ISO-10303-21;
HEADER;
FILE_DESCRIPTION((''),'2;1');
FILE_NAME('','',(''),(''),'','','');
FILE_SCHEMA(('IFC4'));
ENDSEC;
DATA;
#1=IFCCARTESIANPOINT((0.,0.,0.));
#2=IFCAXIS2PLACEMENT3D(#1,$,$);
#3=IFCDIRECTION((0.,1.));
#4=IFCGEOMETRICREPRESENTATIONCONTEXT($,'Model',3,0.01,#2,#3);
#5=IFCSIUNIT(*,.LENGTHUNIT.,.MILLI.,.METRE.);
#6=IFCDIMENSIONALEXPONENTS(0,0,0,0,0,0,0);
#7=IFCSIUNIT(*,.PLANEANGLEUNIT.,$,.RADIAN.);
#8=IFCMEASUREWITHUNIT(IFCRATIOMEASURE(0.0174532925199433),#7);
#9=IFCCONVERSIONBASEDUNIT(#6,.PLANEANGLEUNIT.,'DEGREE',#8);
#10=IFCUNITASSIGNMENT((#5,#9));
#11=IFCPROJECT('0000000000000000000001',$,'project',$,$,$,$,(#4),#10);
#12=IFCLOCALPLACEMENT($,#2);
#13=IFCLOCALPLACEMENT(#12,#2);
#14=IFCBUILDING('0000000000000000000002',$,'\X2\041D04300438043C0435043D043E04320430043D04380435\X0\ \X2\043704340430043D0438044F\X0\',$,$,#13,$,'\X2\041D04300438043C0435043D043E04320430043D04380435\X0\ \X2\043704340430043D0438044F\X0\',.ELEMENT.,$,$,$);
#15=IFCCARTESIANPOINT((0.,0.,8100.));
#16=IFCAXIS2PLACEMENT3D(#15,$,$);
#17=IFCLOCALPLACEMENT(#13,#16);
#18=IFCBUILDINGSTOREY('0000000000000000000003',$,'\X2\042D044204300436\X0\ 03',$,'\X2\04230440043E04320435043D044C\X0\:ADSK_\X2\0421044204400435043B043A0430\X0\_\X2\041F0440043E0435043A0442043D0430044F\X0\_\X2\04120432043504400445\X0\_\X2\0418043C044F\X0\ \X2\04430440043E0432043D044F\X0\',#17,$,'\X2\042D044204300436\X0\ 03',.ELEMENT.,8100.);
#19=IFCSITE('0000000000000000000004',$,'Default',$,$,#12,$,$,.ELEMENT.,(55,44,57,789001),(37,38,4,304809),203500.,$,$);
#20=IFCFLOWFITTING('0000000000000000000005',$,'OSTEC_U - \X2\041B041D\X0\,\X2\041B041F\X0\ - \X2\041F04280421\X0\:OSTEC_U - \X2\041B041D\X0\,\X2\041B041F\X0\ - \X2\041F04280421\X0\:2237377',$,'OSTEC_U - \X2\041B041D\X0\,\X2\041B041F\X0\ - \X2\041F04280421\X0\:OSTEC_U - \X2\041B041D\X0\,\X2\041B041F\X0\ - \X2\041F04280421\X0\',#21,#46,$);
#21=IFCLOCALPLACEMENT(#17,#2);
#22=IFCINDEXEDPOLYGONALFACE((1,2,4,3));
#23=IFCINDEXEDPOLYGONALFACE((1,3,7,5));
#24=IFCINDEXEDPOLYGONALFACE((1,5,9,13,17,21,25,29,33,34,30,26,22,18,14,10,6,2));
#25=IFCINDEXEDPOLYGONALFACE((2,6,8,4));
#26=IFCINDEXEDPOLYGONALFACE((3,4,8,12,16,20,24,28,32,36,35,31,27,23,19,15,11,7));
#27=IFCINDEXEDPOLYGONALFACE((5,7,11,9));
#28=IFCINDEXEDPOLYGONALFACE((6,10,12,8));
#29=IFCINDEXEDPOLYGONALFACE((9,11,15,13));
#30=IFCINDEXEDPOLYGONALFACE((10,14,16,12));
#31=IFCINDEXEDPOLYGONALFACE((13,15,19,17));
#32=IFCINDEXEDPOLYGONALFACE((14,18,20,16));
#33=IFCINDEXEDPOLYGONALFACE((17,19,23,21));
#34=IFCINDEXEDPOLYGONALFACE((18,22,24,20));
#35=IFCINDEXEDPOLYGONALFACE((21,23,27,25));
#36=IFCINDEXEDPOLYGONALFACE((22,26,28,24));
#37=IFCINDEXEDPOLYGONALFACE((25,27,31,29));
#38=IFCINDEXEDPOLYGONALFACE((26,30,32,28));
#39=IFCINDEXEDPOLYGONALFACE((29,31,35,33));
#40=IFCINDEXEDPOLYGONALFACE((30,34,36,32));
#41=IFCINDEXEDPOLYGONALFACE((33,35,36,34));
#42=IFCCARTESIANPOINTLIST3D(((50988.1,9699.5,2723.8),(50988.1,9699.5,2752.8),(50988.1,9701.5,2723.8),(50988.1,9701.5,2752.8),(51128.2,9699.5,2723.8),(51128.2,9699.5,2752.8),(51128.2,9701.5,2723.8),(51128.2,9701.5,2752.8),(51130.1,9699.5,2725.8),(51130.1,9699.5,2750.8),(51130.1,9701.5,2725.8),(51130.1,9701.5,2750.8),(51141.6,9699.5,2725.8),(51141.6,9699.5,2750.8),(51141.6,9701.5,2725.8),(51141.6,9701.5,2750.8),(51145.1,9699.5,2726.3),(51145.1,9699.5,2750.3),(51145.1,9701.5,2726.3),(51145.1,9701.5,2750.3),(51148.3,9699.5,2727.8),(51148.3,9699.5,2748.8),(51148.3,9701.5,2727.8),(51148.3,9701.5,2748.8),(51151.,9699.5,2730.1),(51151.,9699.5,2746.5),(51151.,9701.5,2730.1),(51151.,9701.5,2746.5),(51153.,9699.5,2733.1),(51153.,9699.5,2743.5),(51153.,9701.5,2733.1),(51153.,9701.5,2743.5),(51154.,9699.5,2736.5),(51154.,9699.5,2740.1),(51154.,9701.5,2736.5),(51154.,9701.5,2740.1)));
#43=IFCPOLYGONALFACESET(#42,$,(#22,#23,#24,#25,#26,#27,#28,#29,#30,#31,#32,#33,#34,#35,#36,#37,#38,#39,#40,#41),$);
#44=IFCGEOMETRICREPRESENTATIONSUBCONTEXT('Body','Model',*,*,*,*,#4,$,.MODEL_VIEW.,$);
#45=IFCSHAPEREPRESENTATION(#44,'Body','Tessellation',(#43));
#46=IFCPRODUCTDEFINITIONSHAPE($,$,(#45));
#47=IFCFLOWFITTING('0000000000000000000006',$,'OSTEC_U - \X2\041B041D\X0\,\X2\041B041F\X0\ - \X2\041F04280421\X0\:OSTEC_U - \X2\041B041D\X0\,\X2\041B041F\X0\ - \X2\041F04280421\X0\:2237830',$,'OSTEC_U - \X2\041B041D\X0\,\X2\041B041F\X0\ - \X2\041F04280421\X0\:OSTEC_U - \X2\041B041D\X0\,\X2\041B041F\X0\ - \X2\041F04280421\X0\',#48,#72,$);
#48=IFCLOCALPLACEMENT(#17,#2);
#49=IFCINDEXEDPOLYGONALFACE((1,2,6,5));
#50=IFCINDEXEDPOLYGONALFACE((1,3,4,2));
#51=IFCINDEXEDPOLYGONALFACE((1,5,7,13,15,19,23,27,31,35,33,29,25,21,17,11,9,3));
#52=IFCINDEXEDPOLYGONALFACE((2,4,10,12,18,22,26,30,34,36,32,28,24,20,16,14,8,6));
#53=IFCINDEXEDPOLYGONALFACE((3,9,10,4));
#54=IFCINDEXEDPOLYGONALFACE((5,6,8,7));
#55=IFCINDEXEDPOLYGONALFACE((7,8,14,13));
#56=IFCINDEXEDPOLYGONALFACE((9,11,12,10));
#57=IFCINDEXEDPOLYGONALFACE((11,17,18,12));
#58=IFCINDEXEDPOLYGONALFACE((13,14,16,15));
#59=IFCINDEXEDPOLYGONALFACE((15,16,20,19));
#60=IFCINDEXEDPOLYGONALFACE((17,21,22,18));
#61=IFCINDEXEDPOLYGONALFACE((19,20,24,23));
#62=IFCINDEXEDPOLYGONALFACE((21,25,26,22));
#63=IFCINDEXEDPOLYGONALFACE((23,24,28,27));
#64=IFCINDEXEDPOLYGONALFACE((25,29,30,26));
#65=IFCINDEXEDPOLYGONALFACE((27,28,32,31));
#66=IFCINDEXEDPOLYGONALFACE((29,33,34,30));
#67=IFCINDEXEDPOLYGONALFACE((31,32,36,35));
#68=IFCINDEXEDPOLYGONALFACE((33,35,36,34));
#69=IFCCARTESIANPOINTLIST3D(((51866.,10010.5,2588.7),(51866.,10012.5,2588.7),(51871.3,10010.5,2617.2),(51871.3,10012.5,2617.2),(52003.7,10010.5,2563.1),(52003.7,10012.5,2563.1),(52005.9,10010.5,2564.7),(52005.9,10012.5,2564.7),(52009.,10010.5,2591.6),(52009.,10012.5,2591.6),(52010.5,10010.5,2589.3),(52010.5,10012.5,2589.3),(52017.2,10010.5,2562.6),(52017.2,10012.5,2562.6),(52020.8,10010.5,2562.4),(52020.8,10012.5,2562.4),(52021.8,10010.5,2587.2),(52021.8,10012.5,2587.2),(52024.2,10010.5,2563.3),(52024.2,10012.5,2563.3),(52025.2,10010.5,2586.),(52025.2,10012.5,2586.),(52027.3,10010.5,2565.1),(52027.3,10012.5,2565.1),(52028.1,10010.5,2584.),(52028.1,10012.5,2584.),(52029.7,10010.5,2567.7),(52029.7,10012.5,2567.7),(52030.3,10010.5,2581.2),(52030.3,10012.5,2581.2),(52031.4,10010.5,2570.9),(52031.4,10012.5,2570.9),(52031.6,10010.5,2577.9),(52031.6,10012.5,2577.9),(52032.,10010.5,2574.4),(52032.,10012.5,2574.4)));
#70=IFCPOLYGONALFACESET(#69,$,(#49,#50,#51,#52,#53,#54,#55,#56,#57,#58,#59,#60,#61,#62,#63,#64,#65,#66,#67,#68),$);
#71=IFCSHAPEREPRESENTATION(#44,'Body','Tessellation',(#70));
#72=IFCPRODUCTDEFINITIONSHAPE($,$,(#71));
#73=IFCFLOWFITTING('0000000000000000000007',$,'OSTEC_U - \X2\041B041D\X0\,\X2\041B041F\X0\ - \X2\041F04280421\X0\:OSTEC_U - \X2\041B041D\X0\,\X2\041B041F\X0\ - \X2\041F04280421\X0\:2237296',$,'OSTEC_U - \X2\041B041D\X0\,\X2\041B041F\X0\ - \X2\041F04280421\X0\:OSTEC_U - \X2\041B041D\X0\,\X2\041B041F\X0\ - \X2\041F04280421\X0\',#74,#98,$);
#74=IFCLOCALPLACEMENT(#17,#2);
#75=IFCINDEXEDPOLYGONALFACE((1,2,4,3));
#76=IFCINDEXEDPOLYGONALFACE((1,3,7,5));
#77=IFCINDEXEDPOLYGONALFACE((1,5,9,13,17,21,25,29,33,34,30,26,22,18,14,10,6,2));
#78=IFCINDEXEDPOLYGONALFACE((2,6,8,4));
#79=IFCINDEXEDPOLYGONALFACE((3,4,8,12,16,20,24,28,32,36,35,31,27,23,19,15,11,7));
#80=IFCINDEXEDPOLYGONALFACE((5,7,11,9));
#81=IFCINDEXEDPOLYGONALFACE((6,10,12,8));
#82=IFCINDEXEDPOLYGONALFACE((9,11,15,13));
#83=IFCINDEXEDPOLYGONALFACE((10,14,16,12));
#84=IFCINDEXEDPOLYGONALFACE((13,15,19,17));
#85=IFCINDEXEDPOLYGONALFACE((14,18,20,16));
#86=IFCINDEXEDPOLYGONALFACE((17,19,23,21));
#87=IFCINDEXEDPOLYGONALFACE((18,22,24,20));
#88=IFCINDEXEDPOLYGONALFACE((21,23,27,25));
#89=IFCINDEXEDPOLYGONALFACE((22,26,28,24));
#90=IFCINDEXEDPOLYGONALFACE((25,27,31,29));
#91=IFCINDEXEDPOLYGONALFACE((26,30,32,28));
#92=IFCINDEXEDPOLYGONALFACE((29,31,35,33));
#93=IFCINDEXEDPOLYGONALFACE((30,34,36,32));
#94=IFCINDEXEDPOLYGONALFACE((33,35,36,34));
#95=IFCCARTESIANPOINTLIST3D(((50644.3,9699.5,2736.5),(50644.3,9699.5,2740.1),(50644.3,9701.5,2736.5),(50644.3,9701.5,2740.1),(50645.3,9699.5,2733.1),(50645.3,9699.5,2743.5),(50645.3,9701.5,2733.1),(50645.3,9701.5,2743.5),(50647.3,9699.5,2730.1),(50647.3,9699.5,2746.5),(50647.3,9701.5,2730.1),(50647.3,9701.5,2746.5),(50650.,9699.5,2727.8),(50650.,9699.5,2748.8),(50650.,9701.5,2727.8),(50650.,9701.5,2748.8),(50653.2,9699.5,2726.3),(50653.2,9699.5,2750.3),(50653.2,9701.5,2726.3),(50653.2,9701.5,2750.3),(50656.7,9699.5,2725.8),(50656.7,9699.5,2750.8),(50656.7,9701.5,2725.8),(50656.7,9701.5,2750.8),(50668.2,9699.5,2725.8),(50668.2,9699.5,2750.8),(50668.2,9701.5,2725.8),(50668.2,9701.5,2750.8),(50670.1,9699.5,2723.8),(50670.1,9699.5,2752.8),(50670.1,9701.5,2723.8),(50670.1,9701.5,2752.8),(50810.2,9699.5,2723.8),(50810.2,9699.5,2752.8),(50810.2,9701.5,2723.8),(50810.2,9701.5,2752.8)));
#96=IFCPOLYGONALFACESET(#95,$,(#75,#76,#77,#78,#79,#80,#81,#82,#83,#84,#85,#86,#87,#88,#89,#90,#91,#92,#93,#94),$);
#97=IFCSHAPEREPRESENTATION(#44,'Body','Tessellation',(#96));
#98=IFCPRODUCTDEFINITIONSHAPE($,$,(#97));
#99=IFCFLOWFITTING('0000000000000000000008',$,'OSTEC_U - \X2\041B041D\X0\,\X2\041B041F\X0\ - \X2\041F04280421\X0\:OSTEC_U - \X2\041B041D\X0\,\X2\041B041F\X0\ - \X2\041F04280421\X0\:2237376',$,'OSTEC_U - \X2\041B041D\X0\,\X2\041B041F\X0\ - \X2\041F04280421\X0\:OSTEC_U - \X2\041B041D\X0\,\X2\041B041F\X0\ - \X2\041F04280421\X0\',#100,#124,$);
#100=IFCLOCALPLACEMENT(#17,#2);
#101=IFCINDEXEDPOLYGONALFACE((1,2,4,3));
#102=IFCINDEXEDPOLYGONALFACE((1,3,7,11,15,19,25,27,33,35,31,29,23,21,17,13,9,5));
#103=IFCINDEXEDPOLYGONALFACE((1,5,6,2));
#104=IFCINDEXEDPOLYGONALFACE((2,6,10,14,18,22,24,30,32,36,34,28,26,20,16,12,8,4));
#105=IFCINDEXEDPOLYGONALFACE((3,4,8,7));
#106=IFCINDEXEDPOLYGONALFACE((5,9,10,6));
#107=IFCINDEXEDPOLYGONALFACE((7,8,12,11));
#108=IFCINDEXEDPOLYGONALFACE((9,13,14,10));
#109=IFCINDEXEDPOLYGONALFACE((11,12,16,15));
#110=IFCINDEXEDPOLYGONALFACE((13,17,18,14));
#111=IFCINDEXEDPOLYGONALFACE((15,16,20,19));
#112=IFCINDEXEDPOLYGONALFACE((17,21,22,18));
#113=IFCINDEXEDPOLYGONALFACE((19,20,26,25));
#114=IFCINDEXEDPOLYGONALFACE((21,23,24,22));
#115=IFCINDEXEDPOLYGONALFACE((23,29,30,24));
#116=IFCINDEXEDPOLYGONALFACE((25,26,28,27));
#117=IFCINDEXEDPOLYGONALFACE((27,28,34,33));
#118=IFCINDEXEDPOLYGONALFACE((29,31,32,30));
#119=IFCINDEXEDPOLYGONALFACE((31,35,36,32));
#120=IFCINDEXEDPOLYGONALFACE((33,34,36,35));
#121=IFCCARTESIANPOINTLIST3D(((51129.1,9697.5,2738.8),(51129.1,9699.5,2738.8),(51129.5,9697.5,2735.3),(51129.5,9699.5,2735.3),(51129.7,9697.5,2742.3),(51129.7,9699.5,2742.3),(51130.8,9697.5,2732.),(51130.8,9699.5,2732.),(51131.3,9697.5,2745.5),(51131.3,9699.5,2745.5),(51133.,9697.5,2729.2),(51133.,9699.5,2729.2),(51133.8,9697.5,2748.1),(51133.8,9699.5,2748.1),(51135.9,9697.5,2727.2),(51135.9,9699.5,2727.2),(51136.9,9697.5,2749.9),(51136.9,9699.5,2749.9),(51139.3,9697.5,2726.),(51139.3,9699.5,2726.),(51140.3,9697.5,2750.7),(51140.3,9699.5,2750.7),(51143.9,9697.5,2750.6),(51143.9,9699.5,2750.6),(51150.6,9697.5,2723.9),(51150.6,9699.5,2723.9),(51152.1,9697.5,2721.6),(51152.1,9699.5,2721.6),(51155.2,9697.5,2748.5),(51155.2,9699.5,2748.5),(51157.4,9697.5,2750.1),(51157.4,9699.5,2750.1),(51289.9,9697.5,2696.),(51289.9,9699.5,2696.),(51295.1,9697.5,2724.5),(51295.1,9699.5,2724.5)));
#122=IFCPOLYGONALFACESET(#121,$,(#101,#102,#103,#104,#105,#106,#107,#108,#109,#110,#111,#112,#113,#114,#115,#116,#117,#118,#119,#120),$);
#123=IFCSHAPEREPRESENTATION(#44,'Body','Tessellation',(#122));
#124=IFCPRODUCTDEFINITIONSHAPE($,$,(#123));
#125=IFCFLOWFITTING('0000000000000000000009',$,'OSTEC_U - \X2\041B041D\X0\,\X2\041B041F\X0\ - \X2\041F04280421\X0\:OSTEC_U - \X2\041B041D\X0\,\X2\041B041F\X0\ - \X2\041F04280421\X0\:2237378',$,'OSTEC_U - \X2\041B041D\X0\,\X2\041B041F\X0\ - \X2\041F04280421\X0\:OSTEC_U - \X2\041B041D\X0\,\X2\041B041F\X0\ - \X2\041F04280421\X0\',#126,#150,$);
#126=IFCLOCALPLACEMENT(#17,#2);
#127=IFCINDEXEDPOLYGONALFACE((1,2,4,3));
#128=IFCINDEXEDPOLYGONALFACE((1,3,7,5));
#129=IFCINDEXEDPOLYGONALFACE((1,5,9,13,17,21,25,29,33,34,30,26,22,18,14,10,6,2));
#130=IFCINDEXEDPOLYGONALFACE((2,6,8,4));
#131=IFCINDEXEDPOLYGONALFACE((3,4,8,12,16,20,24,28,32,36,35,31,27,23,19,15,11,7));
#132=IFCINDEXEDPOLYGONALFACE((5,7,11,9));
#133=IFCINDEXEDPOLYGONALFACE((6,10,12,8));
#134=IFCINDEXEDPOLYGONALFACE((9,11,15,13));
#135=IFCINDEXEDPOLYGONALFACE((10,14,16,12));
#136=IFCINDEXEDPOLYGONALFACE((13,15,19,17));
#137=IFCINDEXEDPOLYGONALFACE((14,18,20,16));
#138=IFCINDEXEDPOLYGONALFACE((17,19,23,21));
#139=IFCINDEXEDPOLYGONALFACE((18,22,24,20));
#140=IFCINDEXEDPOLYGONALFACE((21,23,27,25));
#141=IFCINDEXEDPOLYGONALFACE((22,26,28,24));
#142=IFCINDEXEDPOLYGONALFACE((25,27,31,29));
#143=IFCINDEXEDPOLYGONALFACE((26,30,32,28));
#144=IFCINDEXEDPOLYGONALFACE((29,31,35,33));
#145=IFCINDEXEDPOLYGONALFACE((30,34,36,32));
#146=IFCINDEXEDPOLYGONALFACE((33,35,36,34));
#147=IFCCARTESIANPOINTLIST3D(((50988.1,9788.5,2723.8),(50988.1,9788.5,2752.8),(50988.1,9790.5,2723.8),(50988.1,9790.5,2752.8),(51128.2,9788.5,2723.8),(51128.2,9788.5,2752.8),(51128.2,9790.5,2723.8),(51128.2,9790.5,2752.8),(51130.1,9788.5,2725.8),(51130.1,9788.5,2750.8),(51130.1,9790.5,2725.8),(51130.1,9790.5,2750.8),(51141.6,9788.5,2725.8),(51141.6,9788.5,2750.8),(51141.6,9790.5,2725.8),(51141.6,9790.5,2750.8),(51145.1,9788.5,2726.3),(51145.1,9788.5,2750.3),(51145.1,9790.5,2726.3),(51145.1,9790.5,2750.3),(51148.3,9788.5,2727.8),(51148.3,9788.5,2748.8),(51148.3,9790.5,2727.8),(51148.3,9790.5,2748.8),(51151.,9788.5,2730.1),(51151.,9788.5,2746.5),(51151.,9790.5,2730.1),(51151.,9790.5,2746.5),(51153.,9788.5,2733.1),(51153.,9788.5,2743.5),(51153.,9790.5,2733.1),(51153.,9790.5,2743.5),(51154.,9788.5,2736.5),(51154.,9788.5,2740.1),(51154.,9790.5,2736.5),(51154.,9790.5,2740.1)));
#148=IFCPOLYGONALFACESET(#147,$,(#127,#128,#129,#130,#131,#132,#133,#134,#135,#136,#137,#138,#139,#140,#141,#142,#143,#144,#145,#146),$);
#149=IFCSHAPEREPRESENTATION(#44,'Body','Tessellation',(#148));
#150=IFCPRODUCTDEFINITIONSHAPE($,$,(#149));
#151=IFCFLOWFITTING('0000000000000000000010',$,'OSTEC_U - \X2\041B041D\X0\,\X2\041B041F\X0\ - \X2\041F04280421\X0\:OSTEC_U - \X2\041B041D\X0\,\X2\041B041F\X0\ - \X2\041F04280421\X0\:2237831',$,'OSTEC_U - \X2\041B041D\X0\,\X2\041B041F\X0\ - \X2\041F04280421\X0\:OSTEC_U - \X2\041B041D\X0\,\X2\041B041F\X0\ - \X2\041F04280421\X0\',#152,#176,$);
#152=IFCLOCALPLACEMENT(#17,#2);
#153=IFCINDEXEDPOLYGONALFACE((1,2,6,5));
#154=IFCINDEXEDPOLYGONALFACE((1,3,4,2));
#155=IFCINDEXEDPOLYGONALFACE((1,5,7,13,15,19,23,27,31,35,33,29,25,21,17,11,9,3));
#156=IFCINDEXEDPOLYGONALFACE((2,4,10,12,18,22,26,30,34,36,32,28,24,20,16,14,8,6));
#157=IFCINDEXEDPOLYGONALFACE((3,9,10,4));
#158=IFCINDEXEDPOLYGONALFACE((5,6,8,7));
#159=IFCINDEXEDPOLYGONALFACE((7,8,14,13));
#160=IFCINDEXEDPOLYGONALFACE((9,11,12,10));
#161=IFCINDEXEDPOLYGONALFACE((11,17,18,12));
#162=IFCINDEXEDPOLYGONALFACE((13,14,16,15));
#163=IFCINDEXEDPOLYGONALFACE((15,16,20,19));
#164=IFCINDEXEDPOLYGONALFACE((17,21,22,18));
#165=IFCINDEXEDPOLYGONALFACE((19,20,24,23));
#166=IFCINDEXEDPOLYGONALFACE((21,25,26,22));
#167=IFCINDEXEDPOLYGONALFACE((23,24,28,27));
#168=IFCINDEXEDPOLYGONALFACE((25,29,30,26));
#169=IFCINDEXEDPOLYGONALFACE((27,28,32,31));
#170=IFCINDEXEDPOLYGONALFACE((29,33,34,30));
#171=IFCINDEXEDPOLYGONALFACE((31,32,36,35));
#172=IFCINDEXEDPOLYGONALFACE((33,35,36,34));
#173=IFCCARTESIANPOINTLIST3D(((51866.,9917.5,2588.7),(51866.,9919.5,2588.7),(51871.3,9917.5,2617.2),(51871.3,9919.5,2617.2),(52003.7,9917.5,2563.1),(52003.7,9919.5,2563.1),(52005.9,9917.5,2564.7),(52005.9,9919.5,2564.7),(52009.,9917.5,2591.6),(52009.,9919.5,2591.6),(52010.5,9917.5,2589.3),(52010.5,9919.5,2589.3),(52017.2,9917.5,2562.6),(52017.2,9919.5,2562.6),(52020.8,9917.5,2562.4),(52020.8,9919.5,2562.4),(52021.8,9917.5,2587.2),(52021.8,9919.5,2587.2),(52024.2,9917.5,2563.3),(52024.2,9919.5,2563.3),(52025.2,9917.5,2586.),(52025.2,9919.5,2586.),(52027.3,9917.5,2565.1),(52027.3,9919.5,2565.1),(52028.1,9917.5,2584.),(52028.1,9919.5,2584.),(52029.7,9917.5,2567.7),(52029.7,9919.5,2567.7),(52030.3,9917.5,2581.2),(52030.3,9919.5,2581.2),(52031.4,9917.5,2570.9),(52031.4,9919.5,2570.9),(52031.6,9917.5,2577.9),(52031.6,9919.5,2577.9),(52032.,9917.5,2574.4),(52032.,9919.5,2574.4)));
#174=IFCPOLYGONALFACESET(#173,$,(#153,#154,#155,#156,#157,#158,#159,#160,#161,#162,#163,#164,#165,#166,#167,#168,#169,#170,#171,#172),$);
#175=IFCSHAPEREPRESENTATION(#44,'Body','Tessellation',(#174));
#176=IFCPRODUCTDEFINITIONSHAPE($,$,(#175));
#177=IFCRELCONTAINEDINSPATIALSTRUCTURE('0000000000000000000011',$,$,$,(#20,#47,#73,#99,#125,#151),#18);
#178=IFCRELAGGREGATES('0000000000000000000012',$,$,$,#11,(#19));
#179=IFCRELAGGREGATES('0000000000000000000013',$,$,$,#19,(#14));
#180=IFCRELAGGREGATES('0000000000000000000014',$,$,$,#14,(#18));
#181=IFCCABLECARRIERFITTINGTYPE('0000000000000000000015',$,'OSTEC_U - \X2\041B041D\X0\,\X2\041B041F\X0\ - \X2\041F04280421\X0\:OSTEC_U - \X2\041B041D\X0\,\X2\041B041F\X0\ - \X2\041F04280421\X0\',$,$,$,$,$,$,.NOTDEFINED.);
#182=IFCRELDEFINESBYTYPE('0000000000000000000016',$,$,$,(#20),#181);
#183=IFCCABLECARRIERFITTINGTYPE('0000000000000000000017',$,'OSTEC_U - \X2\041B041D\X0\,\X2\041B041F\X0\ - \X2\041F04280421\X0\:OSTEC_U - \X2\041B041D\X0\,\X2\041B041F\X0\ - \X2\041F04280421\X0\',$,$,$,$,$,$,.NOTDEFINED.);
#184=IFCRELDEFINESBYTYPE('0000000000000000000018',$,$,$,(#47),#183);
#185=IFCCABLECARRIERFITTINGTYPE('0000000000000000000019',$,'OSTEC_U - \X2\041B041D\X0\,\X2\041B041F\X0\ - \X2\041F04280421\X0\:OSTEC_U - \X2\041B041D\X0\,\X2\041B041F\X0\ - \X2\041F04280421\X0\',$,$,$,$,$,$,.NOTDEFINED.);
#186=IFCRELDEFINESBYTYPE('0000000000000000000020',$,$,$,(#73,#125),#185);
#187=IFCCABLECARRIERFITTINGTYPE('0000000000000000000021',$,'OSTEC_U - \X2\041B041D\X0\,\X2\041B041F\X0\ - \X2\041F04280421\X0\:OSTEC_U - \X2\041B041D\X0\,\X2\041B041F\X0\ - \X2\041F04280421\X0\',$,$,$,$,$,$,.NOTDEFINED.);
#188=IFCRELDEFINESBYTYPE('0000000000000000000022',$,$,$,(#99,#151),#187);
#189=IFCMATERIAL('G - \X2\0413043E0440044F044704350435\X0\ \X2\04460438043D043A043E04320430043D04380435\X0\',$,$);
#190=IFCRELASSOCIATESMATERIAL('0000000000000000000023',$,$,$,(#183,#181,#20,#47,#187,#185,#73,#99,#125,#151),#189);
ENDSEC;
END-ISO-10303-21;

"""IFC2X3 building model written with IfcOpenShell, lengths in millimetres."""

from ifc_helpers import new_model, entity, si_unit, converted_unit, direction, frame, frame_2d, origin, place, context, subcontext, project, spatial, polyline, circle_curve, parameter, trimmed, segment, composite_curve, outline, extrude, source, transform, mapped, material, type_object, type_shapes, element, save


model = new_model("IFC2X3")

# Units and contexts
model_context = context("Model", 3, precision=0.01, world=origin(), true_north=direction((0.0, 1.0)))
body_context = subcontext(model_context, "Body", "Model", "MODEL_VIEW")
ifc_project = project(units=[si_unit("LENGTHUNIT", "METRE", prefix="MILLI"), converted_unit("PLANEANGLEUNIT", "DEGREE", entity("IfcRatioMeasure", 0.0174532925199433), si_unit("PLANEANGLEUNIT", "RADIAN"), dimensions=[0, 0, 0, 0, 0, 0, 0])], contexts=[model_context])

# Site, building, storey
site_placement = place(None, origin())
site = spatial("IfcSite", under=ifc_project, at=site_placement, Name="Default", CompositionType="ELEMENT", RefLatitude=(55, 44, 57, 789001), RefLongitude=(37, 38, 4, 304809), RefElevation=203500.0)
building_placement = place(site_placement, origin())
building = spatial("IfcBuilding", under=site, at=building_placement, Name="Наименование здания", LongName="Наименование здания", CompositionType="ELEMENT")
storey_placement = place(building_placement, frame((0.0, 0.0, 8100.0)))
storey = spatial("IfcBuildingStorey", under=building, at=storey_placement, Name="Этаж 03", ObjectType="Уровень:ADSK_Стрелка_Проектная_Вверх_Имя уровня", LongName="Этаж 03", CompositionType="ELEMENT", Elevation=8100.0)

# Flow fittings
ifc_material = material(Name="G - Горячее цинкование")
cable_carrier_fitting_type_1 = type_object("IfcCableCarrierFittingType", Name="OSTEC_U - ЛН,ЛП - ПШС:OSTEC_U - ЛН,ЛП - ПШС", PredefinedType="NOTDEFINED", material=ifc_material)
shared_shape_1 = source(origin(), body_context, "Body", "SweptSolid", [
    extrude(outline(composite_curve([segment(trimmed(circle_curve(frame_2d((-44.6, 0.0), x_axis=(1.0, 0.0)), 12.5), [parameter(90.0)], [parameter(270.0)], True, "PARAMETER"), True, "CONTINUOUS"), segment(polyline([(-44.6, -12.5), (-33.1, -12.5)]), True, "CONTINUOUS"), segment(polyline([(-33.1, -12.5), (-31.2, -14.5)]), True, "CONTINUOUS"), segment(polyline([(-31.2, -14.5), (108.9, -14.5)]), True, "CONTINUOUS"), segment(polyline([(108.9, -14.5), (108.9, 14.5)]), True, "CONTINUOUS"), segment(polyline([(108.9, 14.5), (-31.2, 14.5)]), True, "CONTINUOUS"), segment(polyline([(-31.2, 14.5), (-33.1, 12.5)]), True, "CONTINUOUS"), segment(polyline([(-33.1, 12.5), (-44.6, 12.5)]), True, "CONTINUOUS")], self_intersect=False)), frame((44.6, 0.0, 0.0), z_axis=(0.0, 0.0, -1.0), x_axis=(1.0, 0.0, 0.0)), (0.0, 0.0, -1.0), 2.0),
])
type_shapes(cable_carrier_fitting_type_1, [shared_shape_1])
cable_carrier_fitting_type_2 = type_object("IfcCableCarrierFittingType", Name="OSTEC_U - ЛН,ЛП - ПШС:OSTEC_U - ЛН,ЛП - ПШС", PredefinedType="NOTDEFINED", material=ifc_material)
type_shapes(cable_carrier_fitting_type_2, [shared_shape_1])
flow_fitting_1_placement = place(storey_placement, frame((51141.6, 9701.5, 2738.3), z_axis=(-0.000003, -1.0, -0.000016), x_axis=(-1.0, 0.000003, 0.0)))
element("IfcFlowFitting", 1, at=flow_fitting_1_placement, inside=storey, type_object=cable_carrier_fitting_type_2, material=ifc_material, Name="OSTEC_U - ЛН,ЛП - ПШС:OSTEC_U - ЛН,ЛП - ПШС:2237377", ObjectType="OSTEC_U - ЛН,ЛП - ПШС:OSTEC_U - ЛН,ЛП - ПШС", context=body_context, shape_type="MappedRepresentation", body=[
    mapped(shared_shape_1, transform((0.0, 0.0, 0.0), scale=1.0)),
])
flow_fitting_2_placement = place(storey_placement, frame((52019.5, 10010.5, 2574.9), z_axis=(0.0, 1.0, 0.0), x_axis=(-0.983116, 0.0, 0.182982)))
element("IfcFlowFitting", 2, at=flow_fitting_2_placement, inside=storey, type_object=cable_carrier_fitting_type_1, material=ifc_material, Name="OSTEC_U - ЛН,ЛП - ПШС:OSTEC_U - ЛН,ЛП - ПШС:2237830", ObjectType="OSTEC_U - ЛН,ЛП - ПШС:OSTEC_U - ЛН,ЛП - ПШС", context=body_context, shape_type="MappedRepresentation", body=[
    mapped(shared_shape_1, transform((0.0, 0.0, 0.0), scale=1.0)),
])
cable_carrier_fitting_type_3 = type_object("IfcCableCarrierFittingType", Name="OSTEC_U - ЛН,ЛП - ПШС:OSTEC_U - ЛН,ЛП - ПШС", PredefinedType="NOTDEFINED", material=ifc_material)
shared_shape_2 = source(origin(), body_context, "Body", "SweptSolid", [
    extrude(outline(composite_curve([segment(trimmed(circle_curve(frame_2d((-44.6, 0.0), x_axis=(1.0, 0.0)), 12.5), [parameter(90.0)], [parameter(270.0)], True, "PARAMETER"), True, "CONTINUOUS"), segment(polyline([(-44.6, -12.5), (-33.1, -12.5)]), True, "CONTINUOUS"), segment(polyline([(-33.1, -12.5), (-31.2, -14.5)]), True, "CONTINUOUS"), segment(polyline([(-31.2, -14.5), (108.9, -14.5)]), True, "CONTINUOUS"), segment(polyline([(108.9, -14.5), (108.9, 14.5)]), True, "CONTINUOUS"), segment(polyline([(108.9, 14.5), (-31.2, 14.5)]), True, "CONTINUOUS"), segment(polyline([(-31.2, 14.5), (-33.1, 12.5)]), True, "CONTINUOUS"), segment(polyline([(-33.1, 12.5), (-44.6, 12.5)]), True, "CONTINUOUS")], self_intersect=False)), frame((44.6, 0.0, 0.0)), (0.0, 0.0, 1.0), 2.0),
])
type_shapes(cable_carrier_fitting_type_3, [shared_shape_2])
cable_carrier_fitting_type_4 = type_object("IfcCableCarrierFittingType", Name="OSTEC_U - ЛН,ЛП - ПШС:OSTEC_U - ЛН,ЛП - ПШС", PredefinedType="NOTDEFINED", material=ifc_material)
type_shapes(cable_carrier_fitting_type_4, [shared_shape_2])
flow_fitting_3_placement = place(storey_placement, frame((50656.7, 9701.5, 2738.3), z_axis=(-0.000003, -1.0, 0.000015), x_axis=(1.0, -0.000003, 0.0)))
element("IfcFlowFitting", 3, at=flow_fitting_3_placement, inside=storey, type_object=cable_carrier_fitting_type_4, material=ifc_material, Name="OSTEC_U - ЛН,ЛП - ПШС:OSTEC_U - ЛН,ЛП - ПШС:2237296", ObjectType="OSTEC_U - ЛН,ЛП - ПШС:OSTEC_U - ЛН,ЛП - ПШС", context=body_context, shape_type="MappedRepresentation", body=[
    mapped(shared_shape_2, transform((0.0, 0.0, 0.0), scale=1.0)),
])
flow_fitting_4_placement = place(storey_placement, frame((51141.6, 9699.5, 2738.3), z_axis=(-0.000003, -1.0, -0.000016), x_axis=(0.983195, 0.0, -0.182559)))
element("IfcFlowFitting", 4, at=flow_fitting_4_placement, inside=storey, type_object=cable_carrier_fitting_type_3, material=ifc_material, Name="OSTEC_U - ЛН,ЛП - ПШС:OSTEC_U - ЛН,ЛП - ПШС:2237376", ObjectType="OSTEC_U - ЛН,ЛП - ПШС:OSTEC_U - ЛН,ЛП - ПШС", context=body_context, shape_type="MappedRepresentation", body=[
    mapped(shared_shape_2, transform((0.0, 0.0, 0.0), scale=1.0)),
])
flow_fitting_5_placement = place(storey_placement, frame((51141.6, 9788.5, 2738.3), z_axis=(0.000003, 1.0, 0.000016), x_axis=(-1.0, 0.000003, 0.0)))
element("IfcFlowFitting", 5, at=flow_fitting_5_placement, inside=storey, type_object=cable_carrier_fitting_type_4, material=ifc_material, Name="OSTEC_U - ЛН,ЛП - ПШС:OSTEC_U - ЛН,ЛП - ПШС:2237378", ObjectType="OSTEC_U - ЛН,ЛП - ПШС:OSTEC_U - ЛН,ЛП - ПШС", context=body_context, shape_type="MappedRepresentation", body=[
    mapped(shared_shape_2, transform((0.0, 0.0, 0.0), scale=1.0)),
])
flow_fitting_6_placement = place(storey_placement, frame((52019.5, 9919.5, 2574.9), z_axis=(0.0, -1.0, 0.0), x_axis=(-0.983116, 0.0, 0.182982)))
element("IfcFlowFitting", 6, at=flow_fitting_6_placement, inside=storey, type_object=cable_carrier_fitting_type_3, material=ifc_material, Name="OSTEC_U - ЛН,ЛП - ПШС:OSTEC_U - ЛН,ЛП - ПШС:2237831", ObjectType="OSTEC_U - ЛН,ЛП - ПШС:OSTEC_U - ЛН,ЛП - ПШС", context=body_context, shape_type="MappedRepresentation", body=[
    mapped(shared_shape_2, transform((0.0, 0.0, 0.0), scale=1.0)),
])

save(model, "model.ifc")
